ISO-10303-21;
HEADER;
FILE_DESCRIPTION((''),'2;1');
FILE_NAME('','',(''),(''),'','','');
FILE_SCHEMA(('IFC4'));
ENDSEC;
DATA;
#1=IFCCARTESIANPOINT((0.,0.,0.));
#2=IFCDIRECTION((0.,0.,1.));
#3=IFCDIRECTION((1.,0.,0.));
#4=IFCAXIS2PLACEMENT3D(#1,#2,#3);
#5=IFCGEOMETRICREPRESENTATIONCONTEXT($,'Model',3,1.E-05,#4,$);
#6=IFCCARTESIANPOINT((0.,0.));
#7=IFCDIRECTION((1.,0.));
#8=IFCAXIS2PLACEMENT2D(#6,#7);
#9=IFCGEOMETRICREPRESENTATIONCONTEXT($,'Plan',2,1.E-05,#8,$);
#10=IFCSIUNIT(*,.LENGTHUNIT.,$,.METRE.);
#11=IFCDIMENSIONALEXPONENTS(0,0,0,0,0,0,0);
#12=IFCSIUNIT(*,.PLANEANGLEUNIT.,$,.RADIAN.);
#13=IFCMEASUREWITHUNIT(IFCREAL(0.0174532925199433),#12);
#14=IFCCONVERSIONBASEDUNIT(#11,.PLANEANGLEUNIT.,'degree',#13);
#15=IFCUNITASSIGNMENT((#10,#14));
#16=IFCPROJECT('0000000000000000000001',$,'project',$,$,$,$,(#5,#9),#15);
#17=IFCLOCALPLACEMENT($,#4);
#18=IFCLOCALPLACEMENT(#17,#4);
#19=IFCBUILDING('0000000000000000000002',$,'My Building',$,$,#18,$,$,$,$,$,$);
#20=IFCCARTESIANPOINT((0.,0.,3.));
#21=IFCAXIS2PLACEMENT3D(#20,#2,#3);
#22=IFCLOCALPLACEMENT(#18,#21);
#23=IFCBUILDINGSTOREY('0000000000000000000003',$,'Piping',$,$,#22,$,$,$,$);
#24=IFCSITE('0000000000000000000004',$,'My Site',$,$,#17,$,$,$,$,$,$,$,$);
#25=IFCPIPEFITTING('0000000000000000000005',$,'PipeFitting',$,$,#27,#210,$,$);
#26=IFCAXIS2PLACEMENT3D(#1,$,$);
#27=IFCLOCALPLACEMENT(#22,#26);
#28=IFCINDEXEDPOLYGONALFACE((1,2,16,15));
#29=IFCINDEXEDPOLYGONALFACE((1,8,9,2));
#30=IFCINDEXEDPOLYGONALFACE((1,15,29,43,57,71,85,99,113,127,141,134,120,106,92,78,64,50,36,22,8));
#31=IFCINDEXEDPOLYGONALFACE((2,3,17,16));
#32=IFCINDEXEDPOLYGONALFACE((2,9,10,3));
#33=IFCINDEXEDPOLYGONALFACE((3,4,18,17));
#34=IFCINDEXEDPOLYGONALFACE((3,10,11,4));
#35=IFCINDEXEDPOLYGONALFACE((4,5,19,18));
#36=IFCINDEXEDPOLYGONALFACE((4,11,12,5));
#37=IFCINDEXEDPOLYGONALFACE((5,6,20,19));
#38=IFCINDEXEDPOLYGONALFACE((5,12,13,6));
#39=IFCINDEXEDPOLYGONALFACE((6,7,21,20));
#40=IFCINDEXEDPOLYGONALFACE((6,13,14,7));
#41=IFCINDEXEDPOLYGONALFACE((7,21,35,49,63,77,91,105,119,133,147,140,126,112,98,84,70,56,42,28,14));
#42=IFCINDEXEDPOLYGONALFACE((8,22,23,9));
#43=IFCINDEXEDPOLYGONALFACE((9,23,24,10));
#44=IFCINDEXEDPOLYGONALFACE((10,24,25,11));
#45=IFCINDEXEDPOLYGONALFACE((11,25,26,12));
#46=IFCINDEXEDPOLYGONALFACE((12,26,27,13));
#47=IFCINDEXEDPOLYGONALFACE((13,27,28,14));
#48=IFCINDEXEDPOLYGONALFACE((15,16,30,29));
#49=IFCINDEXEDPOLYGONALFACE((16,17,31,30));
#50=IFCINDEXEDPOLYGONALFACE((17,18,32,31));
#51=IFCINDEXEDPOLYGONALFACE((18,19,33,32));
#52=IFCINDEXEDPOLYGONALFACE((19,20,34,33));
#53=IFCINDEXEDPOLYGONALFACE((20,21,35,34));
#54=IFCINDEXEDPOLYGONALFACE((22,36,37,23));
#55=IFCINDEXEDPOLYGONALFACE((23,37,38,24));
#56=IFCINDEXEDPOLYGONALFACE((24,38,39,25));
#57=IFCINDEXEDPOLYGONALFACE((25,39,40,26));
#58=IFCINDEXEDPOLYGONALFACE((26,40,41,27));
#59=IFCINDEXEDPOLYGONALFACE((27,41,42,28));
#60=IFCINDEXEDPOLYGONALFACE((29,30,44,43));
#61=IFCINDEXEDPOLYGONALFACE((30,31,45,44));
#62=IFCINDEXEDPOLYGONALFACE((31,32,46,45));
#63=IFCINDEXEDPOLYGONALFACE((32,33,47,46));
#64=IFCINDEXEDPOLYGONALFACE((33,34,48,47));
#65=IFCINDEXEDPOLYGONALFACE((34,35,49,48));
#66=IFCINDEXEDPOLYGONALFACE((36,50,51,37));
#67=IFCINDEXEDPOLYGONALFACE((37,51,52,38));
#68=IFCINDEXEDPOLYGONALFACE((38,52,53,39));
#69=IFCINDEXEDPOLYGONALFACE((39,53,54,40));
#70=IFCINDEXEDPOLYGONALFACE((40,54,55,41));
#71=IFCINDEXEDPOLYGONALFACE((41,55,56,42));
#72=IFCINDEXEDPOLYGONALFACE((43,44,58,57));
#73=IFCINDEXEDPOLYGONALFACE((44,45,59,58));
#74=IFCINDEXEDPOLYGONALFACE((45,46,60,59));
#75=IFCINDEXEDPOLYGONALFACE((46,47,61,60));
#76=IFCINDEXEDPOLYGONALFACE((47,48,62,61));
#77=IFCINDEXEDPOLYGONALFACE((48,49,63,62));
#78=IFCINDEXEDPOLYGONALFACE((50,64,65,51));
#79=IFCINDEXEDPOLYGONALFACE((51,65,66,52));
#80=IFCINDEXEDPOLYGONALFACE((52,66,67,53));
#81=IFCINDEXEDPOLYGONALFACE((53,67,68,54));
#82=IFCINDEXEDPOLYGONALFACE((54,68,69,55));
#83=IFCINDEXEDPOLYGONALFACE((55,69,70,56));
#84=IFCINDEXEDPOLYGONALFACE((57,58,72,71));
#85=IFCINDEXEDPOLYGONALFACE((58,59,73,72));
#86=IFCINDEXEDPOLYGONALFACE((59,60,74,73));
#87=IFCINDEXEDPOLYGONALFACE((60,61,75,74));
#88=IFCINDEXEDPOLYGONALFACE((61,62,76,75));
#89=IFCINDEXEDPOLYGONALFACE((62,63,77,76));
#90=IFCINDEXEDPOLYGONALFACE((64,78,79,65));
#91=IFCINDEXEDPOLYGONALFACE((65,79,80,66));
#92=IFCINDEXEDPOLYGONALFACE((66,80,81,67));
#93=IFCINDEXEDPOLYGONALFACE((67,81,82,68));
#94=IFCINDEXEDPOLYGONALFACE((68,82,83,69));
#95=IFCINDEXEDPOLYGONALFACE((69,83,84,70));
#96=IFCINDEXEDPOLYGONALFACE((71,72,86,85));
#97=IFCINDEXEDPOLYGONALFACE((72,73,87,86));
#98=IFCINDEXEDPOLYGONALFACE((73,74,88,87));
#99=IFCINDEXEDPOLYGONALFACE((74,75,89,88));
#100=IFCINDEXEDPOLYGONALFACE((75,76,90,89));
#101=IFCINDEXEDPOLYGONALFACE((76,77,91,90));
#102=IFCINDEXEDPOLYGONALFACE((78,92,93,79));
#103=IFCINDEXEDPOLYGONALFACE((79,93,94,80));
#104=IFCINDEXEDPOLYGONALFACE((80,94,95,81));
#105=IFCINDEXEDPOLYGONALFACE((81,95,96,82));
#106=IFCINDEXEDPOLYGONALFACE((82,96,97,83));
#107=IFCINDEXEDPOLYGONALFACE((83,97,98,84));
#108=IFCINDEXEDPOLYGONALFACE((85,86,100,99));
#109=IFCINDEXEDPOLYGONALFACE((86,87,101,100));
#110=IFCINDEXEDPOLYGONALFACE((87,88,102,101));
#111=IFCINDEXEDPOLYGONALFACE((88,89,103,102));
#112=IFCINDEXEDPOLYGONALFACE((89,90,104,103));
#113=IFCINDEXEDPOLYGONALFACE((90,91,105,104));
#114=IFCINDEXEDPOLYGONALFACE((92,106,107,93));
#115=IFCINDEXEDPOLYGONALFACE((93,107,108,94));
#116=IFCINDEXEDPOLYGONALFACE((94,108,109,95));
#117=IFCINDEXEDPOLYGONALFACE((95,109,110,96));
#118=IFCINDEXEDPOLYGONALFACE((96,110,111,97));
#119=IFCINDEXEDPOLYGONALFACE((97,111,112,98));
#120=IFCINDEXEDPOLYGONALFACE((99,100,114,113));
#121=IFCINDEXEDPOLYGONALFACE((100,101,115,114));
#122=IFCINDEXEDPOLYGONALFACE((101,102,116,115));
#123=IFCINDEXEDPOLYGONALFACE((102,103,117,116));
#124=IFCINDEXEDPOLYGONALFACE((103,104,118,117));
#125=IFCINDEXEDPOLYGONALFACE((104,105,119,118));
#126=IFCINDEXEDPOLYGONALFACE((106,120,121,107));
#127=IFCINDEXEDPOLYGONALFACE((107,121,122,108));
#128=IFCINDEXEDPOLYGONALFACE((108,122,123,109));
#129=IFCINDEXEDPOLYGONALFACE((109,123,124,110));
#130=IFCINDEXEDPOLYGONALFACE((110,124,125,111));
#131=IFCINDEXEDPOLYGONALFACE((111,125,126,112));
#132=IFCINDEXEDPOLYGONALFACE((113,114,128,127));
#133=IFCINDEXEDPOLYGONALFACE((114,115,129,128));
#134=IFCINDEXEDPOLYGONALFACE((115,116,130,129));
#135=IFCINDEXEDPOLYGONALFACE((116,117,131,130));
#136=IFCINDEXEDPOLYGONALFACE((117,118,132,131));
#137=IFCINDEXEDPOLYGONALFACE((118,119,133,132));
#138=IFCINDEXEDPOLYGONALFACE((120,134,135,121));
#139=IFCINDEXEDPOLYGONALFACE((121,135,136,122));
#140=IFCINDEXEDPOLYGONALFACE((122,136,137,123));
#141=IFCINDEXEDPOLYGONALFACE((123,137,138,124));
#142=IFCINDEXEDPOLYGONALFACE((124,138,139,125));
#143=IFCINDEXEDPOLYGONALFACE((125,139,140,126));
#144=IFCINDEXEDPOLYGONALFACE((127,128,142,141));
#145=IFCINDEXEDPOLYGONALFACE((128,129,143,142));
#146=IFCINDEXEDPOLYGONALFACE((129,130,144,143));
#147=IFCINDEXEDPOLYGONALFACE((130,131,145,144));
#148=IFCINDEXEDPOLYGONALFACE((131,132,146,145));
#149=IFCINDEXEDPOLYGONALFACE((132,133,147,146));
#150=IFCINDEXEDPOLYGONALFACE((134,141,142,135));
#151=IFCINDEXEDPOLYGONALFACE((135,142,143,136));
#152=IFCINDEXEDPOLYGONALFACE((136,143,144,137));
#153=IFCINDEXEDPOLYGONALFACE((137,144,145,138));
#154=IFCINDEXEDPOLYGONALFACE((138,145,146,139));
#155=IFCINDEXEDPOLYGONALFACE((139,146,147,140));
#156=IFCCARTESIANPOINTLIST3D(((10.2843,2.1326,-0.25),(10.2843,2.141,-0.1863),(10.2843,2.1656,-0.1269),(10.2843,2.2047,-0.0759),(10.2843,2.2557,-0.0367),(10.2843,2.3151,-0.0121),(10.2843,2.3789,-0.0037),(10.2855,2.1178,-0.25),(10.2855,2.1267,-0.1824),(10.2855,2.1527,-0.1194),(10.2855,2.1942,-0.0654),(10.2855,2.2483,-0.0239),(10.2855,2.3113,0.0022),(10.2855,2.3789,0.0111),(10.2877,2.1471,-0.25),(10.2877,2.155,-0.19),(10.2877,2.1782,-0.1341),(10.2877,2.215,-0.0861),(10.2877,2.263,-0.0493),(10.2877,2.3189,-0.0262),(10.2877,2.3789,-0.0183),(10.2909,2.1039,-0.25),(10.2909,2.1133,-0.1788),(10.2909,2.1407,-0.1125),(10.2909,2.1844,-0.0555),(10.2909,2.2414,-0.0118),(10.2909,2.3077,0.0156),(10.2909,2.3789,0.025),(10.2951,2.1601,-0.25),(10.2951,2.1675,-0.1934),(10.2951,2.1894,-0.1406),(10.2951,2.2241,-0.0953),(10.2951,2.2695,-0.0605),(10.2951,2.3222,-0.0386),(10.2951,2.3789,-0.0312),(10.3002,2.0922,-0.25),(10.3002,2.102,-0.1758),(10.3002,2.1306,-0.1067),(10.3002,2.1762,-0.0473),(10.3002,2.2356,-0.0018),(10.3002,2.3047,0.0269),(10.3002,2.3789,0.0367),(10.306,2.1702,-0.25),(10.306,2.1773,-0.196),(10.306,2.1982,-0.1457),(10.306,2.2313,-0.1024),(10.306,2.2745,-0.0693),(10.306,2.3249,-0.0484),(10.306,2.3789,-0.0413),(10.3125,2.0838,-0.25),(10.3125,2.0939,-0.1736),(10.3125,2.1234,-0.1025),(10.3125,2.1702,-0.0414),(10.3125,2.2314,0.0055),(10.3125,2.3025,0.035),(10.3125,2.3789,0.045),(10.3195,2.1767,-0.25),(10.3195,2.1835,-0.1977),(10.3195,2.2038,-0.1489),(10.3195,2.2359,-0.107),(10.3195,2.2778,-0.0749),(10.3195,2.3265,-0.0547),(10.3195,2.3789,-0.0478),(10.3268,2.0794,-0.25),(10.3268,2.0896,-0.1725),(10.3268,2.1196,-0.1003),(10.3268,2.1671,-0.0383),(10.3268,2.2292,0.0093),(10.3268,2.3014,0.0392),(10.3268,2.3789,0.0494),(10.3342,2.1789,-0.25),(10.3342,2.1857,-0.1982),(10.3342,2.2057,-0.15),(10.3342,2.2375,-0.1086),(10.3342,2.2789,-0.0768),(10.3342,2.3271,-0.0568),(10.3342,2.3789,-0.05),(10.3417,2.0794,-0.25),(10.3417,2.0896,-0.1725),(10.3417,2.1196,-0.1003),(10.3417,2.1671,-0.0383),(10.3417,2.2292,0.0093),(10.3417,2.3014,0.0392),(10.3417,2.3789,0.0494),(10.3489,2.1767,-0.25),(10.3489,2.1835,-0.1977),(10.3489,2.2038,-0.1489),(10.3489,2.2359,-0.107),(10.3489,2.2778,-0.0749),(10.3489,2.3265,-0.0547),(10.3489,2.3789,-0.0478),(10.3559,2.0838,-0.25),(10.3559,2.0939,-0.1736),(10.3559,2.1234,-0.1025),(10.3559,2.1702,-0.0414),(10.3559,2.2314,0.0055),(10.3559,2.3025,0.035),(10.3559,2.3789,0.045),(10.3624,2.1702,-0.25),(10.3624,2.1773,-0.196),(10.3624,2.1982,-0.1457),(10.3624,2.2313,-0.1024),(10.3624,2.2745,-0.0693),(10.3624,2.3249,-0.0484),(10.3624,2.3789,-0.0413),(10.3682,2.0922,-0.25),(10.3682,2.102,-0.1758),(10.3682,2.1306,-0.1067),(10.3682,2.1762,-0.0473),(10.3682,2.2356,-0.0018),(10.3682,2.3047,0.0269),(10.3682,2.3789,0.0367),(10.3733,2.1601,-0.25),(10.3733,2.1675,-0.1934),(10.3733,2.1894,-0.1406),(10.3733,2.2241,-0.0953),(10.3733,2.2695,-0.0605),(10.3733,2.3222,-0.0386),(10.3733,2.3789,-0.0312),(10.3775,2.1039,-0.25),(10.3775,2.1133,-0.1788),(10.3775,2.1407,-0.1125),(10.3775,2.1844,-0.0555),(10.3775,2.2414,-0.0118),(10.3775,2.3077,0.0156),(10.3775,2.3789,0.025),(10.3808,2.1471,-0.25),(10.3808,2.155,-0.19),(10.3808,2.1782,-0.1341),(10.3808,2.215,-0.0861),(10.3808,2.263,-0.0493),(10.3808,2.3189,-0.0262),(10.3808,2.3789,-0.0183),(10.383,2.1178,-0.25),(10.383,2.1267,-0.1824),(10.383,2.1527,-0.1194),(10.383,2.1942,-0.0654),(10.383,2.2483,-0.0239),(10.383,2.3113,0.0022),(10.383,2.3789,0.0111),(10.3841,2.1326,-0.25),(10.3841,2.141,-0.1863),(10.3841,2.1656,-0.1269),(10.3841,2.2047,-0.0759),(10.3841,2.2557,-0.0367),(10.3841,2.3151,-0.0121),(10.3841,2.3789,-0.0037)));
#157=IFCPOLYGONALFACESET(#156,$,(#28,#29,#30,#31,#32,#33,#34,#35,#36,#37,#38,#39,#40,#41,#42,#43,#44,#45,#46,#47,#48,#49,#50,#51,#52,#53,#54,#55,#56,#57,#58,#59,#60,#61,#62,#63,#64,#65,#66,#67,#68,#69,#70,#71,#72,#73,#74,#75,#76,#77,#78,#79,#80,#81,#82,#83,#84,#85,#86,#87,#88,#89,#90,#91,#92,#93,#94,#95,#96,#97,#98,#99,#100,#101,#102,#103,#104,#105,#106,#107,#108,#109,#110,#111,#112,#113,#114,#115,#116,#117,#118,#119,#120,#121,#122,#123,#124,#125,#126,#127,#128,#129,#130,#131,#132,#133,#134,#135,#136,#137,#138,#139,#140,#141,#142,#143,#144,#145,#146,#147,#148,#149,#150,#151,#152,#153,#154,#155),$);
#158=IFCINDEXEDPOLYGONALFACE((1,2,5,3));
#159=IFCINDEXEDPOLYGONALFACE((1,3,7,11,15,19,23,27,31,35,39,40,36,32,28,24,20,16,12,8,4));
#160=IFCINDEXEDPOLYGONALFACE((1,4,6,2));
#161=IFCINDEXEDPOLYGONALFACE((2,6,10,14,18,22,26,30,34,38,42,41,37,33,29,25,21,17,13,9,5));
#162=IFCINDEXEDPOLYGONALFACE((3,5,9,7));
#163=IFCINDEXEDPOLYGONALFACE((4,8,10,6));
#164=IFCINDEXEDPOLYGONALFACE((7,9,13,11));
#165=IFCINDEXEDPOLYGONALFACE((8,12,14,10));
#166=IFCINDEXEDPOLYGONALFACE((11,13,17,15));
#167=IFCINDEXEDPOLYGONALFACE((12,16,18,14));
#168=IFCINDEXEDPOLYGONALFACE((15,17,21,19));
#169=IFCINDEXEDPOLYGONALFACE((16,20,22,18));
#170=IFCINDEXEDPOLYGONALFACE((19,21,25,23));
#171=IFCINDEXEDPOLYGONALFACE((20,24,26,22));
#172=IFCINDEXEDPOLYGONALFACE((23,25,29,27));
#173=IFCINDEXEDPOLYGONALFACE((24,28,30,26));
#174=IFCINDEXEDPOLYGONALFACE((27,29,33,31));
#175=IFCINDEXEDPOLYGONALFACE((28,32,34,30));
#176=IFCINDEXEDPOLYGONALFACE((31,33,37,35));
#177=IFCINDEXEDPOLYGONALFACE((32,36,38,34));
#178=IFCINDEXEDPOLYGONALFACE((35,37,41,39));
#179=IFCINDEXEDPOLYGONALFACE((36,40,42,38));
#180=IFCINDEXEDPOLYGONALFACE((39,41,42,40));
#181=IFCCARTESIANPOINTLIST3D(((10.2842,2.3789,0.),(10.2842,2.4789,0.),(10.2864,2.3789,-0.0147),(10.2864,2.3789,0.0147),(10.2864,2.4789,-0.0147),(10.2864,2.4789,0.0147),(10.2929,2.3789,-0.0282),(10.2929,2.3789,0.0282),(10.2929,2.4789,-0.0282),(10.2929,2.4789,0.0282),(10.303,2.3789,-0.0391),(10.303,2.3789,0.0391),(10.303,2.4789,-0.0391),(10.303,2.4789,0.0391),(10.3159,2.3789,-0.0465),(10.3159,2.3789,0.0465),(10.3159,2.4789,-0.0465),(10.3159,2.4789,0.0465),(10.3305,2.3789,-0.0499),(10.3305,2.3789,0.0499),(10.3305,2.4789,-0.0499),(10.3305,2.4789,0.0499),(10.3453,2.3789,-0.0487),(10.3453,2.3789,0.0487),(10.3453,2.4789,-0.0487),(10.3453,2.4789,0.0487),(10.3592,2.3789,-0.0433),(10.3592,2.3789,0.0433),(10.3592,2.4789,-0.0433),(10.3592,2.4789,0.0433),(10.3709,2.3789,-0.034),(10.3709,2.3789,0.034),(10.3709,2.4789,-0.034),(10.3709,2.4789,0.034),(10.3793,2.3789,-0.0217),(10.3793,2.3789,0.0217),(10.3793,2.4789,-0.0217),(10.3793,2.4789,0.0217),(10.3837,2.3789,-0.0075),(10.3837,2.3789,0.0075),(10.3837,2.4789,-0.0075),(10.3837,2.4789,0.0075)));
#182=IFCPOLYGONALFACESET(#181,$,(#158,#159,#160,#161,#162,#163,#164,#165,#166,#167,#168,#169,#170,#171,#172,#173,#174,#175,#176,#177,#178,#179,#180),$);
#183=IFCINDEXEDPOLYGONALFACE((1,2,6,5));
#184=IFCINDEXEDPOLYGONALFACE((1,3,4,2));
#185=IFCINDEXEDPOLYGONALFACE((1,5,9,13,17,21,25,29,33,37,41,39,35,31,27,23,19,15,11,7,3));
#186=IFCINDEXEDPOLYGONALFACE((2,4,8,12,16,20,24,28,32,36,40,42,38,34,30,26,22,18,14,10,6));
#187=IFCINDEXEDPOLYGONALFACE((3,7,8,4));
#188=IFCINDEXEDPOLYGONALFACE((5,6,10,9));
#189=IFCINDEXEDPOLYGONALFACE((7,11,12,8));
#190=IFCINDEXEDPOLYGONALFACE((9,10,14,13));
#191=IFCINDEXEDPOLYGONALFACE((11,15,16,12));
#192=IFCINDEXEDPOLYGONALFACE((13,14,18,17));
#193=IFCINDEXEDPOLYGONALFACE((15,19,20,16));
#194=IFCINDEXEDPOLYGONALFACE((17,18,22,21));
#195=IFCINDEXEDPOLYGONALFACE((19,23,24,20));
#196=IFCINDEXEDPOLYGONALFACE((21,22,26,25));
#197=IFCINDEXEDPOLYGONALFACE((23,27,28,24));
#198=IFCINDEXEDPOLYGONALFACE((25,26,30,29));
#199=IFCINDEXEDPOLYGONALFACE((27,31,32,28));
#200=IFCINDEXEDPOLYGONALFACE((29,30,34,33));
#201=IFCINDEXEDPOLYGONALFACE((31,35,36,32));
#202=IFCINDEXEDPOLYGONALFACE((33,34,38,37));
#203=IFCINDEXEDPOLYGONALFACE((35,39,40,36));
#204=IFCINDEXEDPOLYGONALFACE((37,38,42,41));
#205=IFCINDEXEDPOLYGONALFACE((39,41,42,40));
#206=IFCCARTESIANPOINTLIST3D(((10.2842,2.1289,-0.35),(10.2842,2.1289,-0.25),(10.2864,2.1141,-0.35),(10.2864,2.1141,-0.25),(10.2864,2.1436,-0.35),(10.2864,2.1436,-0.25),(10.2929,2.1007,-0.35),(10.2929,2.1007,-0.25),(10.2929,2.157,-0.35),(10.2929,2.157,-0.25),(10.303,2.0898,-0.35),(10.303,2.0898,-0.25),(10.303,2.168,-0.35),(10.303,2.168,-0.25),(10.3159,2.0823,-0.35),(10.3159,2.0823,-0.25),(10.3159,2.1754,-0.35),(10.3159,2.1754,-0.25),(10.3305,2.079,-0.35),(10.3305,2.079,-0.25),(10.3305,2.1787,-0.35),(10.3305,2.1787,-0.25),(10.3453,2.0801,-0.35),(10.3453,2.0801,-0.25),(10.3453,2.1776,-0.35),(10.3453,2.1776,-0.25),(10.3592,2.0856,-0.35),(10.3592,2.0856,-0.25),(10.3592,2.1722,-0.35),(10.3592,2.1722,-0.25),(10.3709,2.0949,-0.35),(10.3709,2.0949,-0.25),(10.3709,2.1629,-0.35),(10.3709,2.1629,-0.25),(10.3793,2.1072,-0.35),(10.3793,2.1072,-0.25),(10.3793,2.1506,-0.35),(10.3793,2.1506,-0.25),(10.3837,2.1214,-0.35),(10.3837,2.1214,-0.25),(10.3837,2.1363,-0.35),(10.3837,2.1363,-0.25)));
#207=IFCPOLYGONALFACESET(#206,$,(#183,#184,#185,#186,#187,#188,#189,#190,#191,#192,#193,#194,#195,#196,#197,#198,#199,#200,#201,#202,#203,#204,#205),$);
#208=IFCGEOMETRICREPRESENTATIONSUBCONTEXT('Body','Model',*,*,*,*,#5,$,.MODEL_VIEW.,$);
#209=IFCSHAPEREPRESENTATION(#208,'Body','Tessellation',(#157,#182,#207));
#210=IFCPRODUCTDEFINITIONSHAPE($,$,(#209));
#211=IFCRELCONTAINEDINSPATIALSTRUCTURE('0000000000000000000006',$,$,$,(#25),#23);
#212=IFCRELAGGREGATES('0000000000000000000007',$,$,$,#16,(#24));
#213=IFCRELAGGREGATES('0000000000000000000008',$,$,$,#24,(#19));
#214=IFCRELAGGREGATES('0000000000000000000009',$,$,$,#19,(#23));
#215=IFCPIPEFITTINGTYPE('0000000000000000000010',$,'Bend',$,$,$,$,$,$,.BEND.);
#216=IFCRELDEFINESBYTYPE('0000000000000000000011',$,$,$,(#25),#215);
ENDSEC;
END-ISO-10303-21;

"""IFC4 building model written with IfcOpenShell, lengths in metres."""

from ifc_helpers import new_model, entity, si_unit, converted_unit, frame, origin_with_axes, origin_2d_with_axis, place, context, subcontext, project, spatial, circle, extrude, source, transform, mapped, type_object, type_shapes, element, save


model = new_model("IFC4")

# Units and contexts
model_context = context("Model", 3, precision=1e-05, world=origin_with_axes())
plan_context = context("Plan", 2, precision=1e-05, world=origin_2d_with_axis())
body_context = subcontext(model_context, "Body", "Model", "MODEL_VIEW")
ifc_project = project(units=[si_unit("LENGTHUNIT", "METRE"), converted_unit("PLANEANGLEUNIT", "degree", entity("IfcReal", 0.0174532925199433), si_unit("PLANEANGLEUNIT", "RADIAN"), dimensions=[0, 0, 0, 0, 0, 0, 0])], contexts=[model_context, plan_context])

# Site, building, storey
site_placement = place(None, origin_with_axes())
site = spatial("IfcSite", under=ifc_project, at=site_placement, Name="My Site")
building_placement = place(site_placement, origin_with_axes())
building = spatial("IfcBuilding", under=site, at=building_placement, Name="My Building")
storey_placement = place(building_placement, frame((0.0, 0.0, 3.0), z_axis=(0.0, 0.0, 1.0), x_axis=(1.0, 0.0, 0.0)))
storey = spatial("IfcBuildingStorey", under=building, at=storey_placement, Name="Piping")

# Pipe fitting
pipe_fitting_type = type_object("IfcPipeFittingType", Name="Bend", PredefinedType="BEND")
shared_shape = source(origin_with_axes(), body_context, "Body", "SolidModel", [
    entity("IfcSweptDiskSolid", entity("IfcIndexedPolyCurve", entity("IfcCartesianPointList3D", [[0.0, 0.0, -0.1], [0.0, -0.0732, -0.2768], [0.0, -0.25, -0.35]]), [entity("IfcArcIndex", [1, 2, 3])]), 0.05),
    extrude(circle(Radius=0.05), origin_with_axes(), (0.0, 0.0, -1.0), 0.1),
    extrude(circle(Radius=0.05), frame((0.0, -0.25, -0.35), z_axis=(0.0, -1.0, 0.0), x_axis=(1.0, 0.0, 0.0)), (0.0, 0.0, 1.0), 0.1),
])
type_shapes(pipe_fitting_type, [shared_shape])
for number, where, z_axis, x_axis, name in (
    (1, (10.3342, 2.4789, 0.0), (0.0, 1.0, 0.0), (-1.0, 0.0, 0.0), "PipeFitting"),
):
    element("IfcPipeFitting", number, at=place(storey_placement, frame(where, z_axis=z_axis, x_axis=x_axis)), inside=storey, type_object=pipe_fitting_type, Name=name, context=body_context, shape_type="MappedRepresentation", body=[
        mapped(shared_shape, transform((0.0, 0.0, 0.0), x_axis=(1.0, 0.0, 0.0), y_axis=(0.0, 1.0, 0.0), z_axis=(0.0, 0.0, 1.0), scale=1.0)),
    ])

save(model, "model.ifc")
